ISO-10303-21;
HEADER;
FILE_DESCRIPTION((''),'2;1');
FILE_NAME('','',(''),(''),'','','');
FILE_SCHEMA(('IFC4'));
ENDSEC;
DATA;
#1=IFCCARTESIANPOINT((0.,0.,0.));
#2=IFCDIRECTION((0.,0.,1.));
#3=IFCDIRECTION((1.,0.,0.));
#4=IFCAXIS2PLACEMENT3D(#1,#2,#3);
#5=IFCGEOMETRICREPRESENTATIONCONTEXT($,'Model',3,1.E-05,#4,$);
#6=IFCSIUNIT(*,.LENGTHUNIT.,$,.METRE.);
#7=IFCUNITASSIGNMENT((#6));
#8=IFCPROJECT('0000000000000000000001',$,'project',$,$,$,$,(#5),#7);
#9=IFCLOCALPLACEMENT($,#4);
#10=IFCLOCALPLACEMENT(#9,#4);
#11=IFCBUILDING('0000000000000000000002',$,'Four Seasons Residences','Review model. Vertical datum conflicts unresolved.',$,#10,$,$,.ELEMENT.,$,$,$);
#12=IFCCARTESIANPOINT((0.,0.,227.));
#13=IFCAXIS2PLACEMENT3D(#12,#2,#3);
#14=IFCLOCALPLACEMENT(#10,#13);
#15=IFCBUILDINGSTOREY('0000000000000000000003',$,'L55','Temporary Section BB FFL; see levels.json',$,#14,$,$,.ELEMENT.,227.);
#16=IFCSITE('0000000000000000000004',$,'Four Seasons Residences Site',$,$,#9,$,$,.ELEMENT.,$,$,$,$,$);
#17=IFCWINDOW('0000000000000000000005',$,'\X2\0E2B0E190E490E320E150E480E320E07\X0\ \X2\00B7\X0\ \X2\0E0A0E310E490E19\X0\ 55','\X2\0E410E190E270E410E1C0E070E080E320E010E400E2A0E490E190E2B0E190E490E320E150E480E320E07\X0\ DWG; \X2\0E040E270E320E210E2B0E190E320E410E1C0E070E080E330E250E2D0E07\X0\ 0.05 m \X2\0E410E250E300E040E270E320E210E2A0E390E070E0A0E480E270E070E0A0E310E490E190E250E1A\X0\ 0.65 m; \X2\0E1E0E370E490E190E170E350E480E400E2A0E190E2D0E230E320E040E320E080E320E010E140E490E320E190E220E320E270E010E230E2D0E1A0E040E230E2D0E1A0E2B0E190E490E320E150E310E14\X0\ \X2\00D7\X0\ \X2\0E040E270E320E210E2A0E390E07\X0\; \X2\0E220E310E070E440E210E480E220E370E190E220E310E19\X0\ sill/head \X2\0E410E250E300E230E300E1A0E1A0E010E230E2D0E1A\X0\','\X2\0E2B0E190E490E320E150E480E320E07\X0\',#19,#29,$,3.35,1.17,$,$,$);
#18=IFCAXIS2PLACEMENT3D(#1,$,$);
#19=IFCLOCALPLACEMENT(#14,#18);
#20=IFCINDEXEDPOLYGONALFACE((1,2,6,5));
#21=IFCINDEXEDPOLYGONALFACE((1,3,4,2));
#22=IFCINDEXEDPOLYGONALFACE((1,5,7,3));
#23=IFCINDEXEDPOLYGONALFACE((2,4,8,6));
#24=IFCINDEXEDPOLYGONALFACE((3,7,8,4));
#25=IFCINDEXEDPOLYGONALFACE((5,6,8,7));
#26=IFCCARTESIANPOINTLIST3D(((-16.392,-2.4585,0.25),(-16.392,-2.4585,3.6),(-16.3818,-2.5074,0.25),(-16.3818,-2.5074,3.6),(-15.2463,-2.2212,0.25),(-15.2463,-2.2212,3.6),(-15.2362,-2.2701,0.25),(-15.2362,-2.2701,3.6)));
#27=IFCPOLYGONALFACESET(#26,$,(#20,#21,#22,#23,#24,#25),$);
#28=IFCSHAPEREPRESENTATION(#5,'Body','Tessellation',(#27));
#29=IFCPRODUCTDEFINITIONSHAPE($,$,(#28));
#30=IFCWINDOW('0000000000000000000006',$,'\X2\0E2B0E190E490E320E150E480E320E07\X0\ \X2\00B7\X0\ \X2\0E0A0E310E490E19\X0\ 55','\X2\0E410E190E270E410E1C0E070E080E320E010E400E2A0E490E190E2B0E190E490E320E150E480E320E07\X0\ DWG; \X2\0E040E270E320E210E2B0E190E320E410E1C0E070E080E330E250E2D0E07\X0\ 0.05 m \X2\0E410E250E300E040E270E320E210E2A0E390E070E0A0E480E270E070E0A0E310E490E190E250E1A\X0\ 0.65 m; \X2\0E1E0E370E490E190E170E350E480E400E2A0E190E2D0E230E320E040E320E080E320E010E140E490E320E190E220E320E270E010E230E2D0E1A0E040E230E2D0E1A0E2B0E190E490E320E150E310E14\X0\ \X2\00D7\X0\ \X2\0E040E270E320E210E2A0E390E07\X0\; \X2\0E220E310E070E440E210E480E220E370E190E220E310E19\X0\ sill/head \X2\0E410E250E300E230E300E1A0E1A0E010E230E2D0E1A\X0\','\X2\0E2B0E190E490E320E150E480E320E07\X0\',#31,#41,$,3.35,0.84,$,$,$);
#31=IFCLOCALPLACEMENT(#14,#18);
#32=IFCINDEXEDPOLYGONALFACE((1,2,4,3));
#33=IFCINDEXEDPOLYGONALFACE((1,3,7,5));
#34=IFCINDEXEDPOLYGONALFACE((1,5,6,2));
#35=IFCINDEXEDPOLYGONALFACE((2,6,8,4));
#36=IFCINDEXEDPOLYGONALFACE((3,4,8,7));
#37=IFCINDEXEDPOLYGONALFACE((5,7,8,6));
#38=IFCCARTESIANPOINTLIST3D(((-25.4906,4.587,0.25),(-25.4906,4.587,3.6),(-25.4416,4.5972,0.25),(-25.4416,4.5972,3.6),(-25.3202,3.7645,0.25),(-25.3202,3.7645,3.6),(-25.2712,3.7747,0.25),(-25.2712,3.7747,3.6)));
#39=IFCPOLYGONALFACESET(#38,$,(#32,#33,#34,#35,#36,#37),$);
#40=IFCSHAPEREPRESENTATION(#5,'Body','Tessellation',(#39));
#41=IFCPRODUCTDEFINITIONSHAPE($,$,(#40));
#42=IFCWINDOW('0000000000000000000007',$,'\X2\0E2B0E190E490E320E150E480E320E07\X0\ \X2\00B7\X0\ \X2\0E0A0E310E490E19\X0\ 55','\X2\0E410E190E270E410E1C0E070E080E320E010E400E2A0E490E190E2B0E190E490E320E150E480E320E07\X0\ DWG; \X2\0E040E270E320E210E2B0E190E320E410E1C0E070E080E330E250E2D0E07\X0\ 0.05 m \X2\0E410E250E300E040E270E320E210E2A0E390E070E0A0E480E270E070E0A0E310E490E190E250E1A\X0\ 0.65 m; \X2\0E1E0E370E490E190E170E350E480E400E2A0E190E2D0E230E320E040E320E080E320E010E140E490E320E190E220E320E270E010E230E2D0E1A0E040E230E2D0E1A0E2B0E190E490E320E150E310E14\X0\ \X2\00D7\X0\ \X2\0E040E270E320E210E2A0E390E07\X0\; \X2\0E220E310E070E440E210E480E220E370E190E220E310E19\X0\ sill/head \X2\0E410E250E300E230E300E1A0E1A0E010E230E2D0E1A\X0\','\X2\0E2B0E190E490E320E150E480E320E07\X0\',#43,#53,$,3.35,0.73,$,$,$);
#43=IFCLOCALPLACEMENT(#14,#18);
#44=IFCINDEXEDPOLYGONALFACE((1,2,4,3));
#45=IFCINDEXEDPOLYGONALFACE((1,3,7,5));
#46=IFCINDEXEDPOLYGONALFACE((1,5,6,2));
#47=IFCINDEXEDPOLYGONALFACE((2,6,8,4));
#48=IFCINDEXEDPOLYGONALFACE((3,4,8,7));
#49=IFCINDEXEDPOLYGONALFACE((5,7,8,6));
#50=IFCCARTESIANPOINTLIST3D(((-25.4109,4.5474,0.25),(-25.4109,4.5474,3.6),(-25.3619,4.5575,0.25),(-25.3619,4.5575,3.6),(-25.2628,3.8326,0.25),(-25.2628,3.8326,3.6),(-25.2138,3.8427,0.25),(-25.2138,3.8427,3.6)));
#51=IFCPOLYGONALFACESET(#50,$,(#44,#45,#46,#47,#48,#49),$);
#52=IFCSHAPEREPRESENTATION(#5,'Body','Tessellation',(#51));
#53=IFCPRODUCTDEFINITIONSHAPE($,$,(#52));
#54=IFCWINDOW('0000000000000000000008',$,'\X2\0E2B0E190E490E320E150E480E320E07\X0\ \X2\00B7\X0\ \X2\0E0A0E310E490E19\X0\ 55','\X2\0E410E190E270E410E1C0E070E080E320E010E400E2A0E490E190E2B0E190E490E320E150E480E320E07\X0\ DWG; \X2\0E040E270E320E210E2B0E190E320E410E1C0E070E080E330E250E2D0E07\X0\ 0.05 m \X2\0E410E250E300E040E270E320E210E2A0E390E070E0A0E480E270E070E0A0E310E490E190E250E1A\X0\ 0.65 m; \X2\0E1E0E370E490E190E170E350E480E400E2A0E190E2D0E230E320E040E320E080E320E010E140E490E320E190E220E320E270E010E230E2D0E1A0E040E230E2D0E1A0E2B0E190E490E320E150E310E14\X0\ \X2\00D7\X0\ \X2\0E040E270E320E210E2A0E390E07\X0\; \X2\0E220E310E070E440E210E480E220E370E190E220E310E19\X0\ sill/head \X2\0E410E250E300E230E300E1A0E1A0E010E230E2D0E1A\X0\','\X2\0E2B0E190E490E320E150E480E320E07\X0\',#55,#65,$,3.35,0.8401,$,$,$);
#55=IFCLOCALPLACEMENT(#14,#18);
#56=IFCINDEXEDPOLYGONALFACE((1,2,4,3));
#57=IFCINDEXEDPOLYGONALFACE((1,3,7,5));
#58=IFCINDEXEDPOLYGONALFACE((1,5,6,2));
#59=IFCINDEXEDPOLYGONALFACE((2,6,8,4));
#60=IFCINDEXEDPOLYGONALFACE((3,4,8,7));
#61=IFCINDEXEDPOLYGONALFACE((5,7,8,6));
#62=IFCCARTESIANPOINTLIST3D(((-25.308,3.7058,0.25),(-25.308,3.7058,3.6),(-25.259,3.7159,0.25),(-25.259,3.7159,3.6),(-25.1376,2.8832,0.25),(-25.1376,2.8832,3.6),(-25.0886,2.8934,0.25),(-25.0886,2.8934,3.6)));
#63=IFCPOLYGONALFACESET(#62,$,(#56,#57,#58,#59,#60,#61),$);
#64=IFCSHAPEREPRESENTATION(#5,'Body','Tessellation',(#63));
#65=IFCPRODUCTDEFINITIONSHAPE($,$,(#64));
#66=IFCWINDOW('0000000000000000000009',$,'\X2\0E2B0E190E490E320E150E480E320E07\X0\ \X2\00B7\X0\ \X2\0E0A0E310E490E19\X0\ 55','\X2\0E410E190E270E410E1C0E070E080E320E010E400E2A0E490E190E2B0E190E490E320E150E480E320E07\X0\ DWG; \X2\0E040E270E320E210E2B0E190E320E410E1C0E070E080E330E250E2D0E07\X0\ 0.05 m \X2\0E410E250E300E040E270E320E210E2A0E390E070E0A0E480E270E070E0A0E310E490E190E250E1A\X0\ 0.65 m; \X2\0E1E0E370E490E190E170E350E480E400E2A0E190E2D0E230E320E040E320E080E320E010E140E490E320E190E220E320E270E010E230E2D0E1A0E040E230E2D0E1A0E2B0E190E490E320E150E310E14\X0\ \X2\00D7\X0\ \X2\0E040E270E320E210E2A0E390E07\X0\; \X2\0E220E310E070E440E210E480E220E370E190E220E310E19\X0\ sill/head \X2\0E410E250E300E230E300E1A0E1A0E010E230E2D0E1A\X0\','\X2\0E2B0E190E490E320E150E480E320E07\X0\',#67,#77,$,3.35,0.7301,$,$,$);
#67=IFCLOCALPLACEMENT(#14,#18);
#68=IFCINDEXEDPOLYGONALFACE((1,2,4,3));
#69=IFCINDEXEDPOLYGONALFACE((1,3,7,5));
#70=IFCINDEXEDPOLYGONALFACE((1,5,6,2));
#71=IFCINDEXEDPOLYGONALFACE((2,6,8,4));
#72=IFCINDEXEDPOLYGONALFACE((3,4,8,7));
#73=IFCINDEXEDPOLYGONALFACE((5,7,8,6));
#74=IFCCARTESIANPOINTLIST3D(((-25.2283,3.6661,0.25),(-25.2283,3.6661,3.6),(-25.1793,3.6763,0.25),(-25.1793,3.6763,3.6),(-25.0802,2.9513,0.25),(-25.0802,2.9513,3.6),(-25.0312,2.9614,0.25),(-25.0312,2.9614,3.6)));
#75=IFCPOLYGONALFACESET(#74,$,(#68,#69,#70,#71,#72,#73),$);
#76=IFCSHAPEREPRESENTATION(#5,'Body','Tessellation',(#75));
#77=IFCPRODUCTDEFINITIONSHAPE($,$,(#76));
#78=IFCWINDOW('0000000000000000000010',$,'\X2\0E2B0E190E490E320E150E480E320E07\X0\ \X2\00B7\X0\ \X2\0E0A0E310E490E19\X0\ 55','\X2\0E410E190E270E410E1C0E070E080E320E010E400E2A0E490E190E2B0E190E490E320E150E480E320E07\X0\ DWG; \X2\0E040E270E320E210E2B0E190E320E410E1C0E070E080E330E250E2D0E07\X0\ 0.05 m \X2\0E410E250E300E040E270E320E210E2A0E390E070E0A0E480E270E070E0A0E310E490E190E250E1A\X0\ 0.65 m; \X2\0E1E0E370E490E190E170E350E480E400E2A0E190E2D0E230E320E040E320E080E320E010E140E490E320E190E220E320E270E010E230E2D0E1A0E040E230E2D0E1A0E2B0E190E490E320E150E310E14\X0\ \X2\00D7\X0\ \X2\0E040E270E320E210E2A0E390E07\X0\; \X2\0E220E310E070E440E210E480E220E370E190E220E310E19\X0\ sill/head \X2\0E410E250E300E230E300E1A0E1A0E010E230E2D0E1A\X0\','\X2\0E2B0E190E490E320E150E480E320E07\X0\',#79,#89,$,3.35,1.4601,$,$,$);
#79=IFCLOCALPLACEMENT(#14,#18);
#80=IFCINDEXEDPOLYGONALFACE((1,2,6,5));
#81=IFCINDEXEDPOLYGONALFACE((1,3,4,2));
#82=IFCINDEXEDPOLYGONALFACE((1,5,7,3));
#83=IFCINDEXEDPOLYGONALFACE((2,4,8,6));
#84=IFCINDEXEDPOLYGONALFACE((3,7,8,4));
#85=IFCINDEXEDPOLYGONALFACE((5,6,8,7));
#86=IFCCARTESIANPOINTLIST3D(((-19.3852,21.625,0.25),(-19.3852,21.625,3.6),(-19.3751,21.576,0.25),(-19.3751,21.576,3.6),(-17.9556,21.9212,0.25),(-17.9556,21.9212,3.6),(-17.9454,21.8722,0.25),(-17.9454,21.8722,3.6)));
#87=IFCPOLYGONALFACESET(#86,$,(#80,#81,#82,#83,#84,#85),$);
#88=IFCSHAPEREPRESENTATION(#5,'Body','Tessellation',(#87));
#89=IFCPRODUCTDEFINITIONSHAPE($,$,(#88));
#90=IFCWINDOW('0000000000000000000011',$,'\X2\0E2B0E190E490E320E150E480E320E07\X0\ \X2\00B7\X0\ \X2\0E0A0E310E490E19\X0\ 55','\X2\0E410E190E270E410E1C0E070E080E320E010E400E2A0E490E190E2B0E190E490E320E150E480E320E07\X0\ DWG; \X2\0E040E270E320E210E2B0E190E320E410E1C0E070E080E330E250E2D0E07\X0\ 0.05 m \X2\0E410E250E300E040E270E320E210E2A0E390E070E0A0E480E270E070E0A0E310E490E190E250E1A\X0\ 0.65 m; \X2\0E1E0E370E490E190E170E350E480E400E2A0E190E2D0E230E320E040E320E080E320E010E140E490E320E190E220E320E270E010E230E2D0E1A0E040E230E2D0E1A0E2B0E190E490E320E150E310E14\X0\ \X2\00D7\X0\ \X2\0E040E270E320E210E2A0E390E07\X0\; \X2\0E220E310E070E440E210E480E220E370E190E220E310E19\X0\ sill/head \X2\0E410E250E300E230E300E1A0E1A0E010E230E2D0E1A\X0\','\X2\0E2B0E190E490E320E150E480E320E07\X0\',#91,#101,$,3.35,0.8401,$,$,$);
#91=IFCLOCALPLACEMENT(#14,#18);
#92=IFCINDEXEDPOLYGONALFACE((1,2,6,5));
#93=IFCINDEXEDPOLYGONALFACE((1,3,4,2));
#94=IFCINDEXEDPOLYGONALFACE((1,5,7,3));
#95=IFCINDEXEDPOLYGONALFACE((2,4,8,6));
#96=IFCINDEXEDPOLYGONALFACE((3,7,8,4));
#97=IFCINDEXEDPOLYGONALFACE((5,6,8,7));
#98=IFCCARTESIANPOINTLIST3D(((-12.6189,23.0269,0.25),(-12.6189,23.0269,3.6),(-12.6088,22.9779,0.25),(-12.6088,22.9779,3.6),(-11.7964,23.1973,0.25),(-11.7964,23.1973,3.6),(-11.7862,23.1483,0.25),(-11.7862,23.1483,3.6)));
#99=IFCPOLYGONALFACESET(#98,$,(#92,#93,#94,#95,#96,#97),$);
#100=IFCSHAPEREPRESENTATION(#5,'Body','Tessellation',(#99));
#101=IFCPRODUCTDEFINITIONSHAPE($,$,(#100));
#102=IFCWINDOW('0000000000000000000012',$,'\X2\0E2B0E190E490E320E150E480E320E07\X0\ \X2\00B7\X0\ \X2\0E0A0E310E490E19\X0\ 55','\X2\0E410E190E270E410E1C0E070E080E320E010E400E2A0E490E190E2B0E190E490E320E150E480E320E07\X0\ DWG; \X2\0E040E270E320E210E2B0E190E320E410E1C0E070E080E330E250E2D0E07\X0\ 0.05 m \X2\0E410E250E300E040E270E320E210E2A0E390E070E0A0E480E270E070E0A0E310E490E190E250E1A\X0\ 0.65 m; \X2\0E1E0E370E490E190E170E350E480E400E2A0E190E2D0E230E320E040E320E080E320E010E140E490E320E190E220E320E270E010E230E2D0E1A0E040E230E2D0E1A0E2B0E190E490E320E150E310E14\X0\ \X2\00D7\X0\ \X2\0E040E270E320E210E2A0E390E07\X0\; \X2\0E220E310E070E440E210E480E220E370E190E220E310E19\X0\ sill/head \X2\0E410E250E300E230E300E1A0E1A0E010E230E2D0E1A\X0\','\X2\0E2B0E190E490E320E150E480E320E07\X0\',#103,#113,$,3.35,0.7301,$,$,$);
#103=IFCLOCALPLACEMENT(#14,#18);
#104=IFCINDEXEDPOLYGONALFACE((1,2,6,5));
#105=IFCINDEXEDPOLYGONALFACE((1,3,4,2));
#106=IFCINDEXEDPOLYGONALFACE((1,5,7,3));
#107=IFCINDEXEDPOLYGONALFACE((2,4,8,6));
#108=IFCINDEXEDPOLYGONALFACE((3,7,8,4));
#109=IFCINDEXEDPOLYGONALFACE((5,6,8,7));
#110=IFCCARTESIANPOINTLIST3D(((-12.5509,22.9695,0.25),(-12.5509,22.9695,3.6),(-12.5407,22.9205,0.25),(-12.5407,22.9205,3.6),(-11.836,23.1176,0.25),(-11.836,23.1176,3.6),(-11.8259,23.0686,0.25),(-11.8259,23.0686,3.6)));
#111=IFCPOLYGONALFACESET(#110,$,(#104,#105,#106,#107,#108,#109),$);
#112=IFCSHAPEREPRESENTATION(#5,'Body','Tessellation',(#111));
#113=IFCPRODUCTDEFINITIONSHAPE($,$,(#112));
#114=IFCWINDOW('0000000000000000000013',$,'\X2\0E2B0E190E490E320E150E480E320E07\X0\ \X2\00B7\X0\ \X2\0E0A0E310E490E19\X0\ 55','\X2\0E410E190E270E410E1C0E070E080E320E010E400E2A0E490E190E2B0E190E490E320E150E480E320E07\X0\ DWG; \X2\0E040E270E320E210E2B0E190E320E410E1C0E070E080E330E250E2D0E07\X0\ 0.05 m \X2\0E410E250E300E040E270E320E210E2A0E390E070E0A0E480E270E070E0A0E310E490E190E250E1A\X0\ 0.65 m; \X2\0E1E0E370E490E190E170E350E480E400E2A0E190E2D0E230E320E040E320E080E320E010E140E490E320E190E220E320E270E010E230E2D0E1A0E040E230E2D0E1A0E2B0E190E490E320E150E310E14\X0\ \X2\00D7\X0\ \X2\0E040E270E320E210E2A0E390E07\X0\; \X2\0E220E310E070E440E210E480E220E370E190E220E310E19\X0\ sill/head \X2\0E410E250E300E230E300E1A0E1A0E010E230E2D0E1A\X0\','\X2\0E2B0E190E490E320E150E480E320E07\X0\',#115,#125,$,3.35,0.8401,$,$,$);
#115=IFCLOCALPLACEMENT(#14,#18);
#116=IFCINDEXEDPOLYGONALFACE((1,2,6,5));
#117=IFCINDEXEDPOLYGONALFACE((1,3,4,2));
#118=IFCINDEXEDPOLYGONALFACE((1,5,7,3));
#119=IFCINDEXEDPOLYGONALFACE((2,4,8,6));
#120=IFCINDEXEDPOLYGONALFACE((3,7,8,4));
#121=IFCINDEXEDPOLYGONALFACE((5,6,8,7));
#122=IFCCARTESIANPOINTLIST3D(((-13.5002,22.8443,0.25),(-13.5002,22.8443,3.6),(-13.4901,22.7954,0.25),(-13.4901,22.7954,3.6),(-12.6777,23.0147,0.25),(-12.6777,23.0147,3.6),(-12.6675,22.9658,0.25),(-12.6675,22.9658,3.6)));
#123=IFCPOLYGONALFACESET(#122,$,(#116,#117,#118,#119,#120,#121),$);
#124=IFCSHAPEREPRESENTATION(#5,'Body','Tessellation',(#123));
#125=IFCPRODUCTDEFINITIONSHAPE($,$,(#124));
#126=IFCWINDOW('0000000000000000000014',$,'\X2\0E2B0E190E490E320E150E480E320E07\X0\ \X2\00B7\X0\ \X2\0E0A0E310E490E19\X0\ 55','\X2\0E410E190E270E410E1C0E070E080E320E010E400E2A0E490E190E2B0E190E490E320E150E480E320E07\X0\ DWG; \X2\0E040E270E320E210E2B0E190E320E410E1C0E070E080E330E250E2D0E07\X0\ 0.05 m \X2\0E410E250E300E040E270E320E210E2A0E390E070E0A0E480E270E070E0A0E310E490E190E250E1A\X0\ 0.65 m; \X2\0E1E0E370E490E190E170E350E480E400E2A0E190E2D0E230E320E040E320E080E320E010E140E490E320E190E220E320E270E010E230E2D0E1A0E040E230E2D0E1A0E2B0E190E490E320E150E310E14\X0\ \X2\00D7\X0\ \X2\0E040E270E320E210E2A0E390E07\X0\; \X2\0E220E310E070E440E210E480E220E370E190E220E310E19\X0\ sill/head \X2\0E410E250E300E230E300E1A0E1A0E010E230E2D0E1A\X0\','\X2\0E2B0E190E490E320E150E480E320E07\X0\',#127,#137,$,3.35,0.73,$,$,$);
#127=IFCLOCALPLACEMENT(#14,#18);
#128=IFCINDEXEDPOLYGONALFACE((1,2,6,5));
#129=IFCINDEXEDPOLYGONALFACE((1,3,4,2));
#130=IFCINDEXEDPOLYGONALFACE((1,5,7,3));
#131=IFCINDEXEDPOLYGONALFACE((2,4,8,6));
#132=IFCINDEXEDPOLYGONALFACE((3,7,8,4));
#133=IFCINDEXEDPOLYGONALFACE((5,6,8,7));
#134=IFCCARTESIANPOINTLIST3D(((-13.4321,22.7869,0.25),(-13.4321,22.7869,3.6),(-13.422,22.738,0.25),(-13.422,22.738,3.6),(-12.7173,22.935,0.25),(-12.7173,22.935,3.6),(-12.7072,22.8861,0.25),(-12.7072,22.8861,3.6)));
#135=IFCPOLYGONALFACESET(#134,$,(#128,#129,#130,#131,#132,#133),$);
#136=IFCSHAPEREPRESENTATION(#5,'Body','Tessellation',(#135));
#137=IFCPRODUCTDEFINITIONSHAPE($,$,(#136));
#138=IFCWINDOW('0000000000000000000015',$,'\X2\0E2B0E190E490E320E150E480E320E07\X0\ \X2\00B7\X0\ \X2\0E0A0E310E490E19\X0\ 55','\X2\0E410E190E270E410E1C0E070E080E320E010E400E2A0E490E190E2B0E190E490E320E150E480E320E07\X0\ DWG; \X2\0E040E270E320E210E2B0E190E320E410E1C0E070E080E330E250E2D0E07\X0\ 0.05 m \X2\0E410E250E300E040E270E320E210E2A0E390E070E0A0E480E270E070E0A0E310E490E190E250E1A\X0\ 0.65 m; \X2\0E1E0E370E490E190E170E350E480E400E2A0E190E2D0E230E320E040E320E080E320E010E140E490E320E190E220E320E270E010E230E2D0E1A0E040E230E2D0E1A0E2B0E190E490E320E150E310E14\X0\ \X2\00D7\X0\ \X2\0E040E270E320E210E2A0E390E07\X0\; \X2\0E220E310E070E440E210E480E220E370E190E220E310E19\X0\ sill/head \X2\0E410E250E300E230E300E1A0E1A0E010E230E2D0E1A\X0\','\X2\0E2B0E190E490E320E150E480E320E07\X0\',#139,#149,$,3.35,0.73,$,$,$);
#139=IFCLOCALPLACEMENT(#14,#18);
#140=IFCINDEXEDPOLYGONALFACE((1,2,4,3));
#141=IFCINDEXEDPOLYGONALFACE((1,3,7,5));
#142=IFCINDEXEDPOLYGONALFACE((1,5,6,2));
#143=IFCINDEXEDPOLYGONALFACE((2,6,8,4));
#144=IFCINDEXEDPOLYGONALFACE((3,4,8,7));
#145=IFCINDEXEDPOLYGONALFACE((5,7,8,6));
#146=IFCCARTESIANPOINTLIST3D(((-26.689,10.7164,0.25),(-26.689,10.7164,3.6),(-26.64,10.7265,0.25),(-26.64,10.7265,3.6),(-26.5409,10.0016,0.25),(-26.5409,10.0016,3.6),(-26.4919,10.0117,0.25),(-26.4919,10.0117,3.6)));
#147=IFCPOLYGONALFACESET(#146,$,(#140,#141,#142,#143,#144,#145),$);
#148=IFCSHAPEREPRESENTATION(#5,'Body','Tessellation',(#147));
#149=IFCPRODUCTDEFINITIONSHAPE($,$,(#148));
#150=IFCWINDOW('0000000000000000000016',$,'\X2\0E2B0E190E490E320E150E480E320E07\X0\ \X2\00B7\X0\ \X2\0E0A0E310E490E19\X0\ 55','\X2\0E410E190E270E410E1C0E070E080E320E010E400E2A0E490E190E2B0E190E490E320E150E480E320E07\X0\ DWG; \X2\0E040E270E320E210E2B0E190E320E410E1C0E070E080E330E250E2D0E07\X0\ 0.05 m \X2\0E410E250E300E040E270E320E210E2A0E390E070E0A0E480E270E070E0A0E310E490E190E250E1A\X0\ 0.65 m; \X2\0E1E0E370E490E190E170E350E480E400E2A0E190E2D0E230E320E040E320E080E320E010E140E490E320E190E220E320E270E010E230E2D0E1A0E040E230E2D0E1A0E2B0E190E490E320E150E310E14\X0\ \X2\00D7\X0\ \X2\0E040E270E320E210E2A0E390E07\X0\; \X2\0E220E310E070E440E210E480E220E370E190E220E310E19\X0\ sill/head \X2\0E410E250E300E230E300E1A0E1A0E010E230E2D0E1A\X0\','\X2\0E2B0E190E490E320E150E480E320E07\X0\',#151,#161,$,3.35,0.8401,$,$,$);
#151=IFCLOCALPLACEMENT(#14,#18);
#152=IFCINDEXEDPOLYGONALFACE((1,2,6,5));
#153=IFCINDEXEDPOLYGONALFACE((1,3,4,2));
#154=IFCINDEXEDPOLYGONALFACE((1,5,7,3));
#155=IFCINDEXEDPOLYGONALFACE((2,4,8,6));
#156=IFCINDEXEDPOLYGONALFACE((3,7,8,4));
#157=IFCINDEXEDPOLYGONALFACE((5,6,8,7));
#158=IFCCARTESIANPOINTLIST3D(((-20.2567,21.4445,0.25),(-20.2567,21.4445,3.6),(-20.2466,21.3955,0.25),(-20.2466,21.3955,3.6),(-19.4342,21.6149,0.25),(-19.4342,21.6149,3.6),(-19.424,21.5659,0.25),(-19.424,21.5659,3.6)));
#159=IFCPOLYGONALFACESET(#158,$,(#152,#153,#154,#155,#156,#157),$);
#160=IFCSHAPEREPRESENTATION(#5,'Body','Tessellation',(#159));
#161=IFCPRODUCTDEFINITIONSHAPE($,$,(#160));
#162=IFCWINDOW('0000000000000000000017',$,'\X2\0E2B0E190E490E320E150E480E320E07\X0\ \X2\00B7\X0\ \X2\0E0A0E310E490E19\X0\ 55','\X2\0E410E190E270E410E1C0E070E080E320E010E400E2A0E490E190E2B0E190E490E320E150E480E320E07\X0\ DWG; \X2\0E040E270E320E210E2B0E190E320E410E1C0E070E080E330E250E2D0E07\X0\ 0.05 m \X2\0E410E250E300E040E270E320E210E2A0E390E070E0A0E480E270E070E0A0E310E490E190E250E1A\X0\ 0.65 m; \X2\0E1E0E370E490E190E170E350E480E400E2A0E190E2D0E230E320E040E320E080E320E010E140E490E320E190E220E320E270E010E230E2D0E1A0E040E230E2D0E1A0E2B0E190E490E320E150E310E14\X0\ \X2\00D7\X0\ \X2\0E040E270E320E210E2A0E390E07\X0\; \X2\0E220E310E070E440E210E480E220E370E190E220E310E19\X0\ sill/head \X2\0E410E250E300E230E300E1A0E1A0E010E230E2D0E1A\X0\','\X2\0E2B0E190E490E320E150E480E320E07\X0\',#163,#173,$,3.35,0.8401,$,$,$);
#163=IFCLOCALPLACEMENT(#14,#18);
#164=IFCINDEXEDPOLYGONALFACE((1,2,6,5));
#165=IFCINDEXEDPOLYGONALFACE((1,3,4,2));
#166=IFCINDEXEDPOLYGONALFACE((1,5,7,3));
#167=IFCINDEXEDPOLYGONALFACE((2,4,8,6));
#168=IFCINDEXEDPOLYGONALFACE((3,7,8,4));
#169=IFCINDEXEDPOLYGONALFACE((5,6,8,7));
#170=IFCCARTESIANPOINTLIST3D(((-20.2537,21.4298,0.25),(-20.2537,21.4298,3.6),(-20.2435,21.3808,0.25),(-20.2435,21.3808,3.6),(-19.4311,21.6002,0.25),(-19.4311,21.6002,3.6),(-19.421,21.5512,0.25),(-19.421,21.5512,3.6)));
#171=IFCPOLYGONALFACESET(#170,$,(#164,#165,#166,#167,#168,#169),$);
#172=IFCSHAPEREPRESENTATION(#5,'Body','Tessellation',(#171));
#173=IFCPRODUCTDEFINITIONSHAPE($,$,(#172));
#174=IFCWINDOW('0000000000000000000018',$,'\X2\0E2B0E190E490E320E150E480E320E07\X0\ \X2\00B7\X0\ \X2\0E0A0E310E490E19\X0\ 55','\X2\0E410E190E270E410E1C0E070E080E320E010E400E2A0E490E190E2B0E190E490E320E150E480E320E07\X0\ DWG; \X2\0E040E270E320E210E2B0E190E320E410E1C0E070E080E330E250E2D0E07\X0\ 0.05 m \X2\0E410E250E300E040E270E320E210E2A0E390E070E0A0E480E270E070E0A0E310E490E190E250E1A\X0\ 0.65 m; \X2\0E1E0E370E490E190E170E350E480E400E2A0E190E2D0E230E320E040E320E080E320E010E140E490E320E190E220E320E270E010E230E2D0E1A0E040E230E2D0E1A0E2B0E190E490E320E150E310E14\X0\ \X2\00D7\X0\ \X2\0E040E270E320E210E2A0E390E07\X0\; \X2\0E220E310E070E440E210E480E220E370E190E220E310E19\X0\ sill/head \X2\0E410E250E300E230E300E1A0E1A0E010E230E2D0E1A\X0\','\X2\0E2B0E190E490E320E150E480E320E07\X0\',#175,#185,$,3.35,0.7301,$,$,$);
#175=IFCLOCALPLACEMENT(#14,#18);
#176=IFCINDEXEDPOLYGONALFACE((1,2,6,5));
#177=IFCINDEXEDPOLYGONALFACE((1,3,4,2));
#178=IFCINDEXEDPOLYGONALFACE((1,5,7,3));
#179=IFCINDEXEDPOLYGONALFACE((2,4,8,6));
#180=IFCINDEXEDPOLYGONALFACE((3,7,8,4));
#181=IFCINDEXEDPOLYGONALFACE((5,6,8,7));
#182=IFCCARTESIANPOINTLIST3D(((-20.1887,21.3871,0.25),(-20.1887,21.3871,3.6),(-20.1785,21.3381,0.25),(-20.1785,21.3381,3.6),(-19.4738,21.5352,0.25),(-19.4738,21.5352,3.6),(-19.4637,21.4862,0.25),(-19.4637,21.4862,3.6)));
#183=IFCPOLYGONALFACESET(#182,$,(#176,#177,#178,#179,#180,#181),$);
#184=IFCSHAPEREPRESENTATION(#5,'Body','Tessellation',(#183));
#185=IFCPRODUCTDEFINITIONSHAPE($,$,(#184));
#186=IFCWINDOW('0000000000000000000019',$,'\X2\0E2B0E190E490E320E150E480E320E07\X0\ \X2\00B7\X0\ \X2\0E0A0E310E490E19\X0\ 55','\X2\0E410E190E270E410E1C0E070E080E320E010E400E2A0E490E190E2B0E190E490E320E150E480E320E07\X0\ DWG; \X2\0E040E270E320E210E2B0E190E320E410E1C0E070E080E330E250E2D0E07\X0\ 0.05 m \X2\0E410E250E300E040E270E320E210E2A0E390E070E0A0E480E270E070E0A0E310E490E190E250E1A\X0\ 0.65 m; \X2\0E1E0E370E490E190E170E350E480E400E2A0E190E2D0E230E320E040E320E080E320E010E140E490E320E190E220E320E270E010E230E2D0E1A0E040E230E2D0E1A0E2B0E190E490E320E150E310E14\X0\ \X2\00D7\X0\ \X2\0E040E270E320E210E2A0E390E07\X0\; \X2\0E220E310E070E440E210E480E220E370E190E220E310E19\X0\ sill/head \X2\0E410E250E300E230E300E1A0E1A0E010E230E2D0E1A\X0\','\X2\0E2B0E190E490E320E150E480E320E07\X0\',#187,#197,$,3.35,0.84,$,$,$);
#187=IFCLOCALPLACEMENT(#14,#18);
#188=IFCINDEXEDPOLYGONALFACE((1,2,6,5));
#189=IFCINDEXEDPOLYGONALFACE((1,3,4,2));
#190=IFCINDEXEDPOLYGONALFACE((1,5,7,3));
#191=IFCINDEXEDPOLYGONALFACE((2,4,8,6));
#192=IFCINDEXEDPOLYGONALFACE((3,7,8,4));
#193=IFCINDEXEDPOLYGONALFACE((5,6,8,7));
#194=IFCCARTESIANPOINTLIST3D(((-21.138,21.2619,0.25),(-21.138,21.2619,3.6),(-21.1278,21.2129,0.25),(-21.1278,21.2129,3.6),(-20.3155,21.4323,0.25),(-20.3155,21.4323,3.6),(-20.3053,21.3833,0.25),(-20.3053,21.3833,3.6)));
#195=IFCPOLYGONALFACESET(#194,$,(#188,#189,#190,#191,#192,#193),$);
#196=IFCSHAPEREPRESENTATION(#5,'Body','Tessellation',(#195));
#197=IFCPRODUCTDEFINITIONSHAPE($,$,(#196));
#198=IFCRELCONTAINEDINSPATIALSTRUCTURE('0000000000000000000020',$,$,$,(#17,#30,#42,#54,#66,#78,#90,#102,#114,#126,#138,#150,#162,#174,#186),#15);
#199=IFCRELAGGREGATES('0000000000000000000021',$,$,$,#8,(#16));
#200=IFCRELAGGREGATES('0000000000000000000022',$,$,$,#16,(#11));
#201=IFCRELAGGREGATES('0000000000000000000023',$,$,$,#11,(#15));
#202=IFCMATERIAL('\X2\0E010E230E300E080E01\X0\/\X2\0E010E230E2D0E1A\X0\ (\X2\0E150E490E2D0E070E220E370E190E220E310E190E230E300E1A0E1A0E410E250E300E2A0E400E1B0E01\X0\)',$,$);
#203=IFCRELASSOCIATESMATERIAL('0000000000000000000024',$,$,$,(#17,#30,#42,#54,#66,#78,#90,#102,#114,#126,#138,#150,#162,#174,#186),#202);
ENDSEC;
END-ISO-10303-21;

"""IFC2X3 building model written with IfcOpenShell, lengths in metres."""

from ifc_helpers import new_model, si_unit, frame, origin_with_axes, place, context, project, spatial, polyline, outline, extrude, material, element, save


model = new_model("IFC2X3")

# Units and contexts
model_context = context("Model", 3, precision=1e-05, world=origin_with_axes())
ifc_project = project(units=[si_unit("LENGTHUNIT", "METRE")], contexts=[model_context])

# Site, building, storey
site_placement = place(None, origin_with_axes())
site = spatial("IfcSite", under=ifc_project, at=site_placement, Name="Four Seasons Residences Site", CompositionType="ELEMENT")
building_placement = place(site_placement, origin_with_axes())
building = spatial("IfcBuilding", under=site, at=building_placement, Name="Four Seasons Residences", Description="Review model. Vertical datum conflicts unresolved.", CompositionType="ELEMENT")
storey_placement = place(building_placement, frame((0.0, 0.0, 227.0), z_axis=(0.0, 0.0, 1.0), x_axis=(1.0, 0.0, 0.0)))
storey = spatial("IfcBuildingStorey", under=building, at=storey_placement, Name="L55", Description="Temporary Section BB FFL; see levels.json", CompositionType="ELEMENT", Elevation=227.0)

# Windows
ifc_material = material(Name="กระจก/กรอบ (ต้องยืนยันระบบและสเปก)")
window_1_placement = place(storey_placement, origin_with_axes())
element("IfcWindow", 1, at=window_1_placement, inside=storey, material=ifc_material, Name="หน้าต่าง · ชั้น 55", Description="แนวแผงจากเส้นหน้าต่าง DWG; ความหนาแผงจำลอง 0.05 m และความสูงช่วงชั้นลบ 0.65 m; พื้นที่เสนอราคาจากด้านยาวกรอบครอบหน้าตัด × ความสูง; ยังไม่ยืนยัน sill/head และระบบกรอบ", ObjectType="หน้าต่าง", OverallHeight=3.35, OverallWidth=1.17, context=model_context, shape_type="SweptSolid", body=[
    extrude(outline(polyline([(-15.2463, -2.2212), (-15.2362, -2.2701), (-16.3818, -2.5074), (-16.392, -2.4585), (-15.2463, -2.2212)])), frame((0.0, 0.0, 0.25), z_axis=(0.0, 0.0, 1.0), x_axis=(1.0, 0.0, 0.0)), (0.0, 0.0, 1.0), 3.35),
])
window_2_placement = place(storey_placement, origin_with_axes())
element("IfcWindow", 2, at=window_2_placement, inside=storey, material=ifc_material, Name="หน้าต่าง · ชั้น 55", Description="แนวแผงจากเส้นหน้าต่าง DWG; ความหนาแผงจำลอง 0.05 m และความสูงช่วงชั้นลบ 0.65 m; พื้นที่เสนอราคาจากด้านยาวกรอบครอบหน้าตัด × ความสูง; ยังไม่ยืนยัน sill/head และระบบกรอบ", ObjectType="หน้าต่าง", OverallHeight=3.35, OverallWidth=0.84, context=model_context, shape_type="SweptSolid", body=[
    extrude(outline(polyline([(-25.2712, 3.7747), (-25.3202, 3.7645), (-25.4906, 4.587), (-25.4416, 4.5972), (-25.2712, 3.7747)])), frame((0.0, 0.0, 0.25), z_axis=(0.0, 0.0, 1.0), x_axis=(1.0, 0.0, 0.0)), (0.0, 0.0, 1.0), 3.35),
])
window_3_placement = place(storey_placement, origin_with_axes())
element("IfcWindow", 3, at=window_3_placement, inside=storey, material=ifc_material, Name="หน้าต่าง · ชั้น 55", Description="แนวแผงจากเส้นหน้าต่าง DWG; ความหนาแผงจำลอง 0.05 m และความสูงช่วงชั้นลบ 0.65 m; พื้นที่เสนอราคาจากด้านยาวกรอบครอบหน้าตัด × ความสูง; ยังไม่ยืนยัน sill/head และระบบกรอบ", ObjectType="หน้าต่าง", OverallHeight=3.35, OverallWidth=0.73, context=model_context, shape_type="SweptSolid", body=[
    extrude(outline(polyline([(-25.2138, 3.8427), (-25.2628, 3.8326), (-25.4109, 4.5474), (-25.3619, 4.5575), (-25.2138, 3.8427)])), frame((0.0, 0.0, 0.25), z_axis=(0.0, 0.0, 1.0), x_axis=(1.0, 0.0, 0.0)), (0.0, 0.0, 1.0), 3.35),
])
window_4_placement = place(storey_placement, origin_with_axes())
element("IfcWindow", 4, at=window_4_placement, inside=storey, material=ifc_material, Name="หน้าต่าง · ชั้น 55", Description="แนวแผงจากเส้นหน้าต่าง DWG; ความหนาแผงจำลอง 0.05 m และความสูงช่วงชั้นลบ 0.65 m; พื้นที่เสนอราคาจากด้านยาวกรอบครอบหน้าตัด × ความสูง; ยังไม่ยืนยัน sill/head และระบบกรอบ", ObjectType="หน้าต่าง", OverallHeight=3.35, OverallWidth=0.8401, context=model_context, shape_type="SweptSolid", body=[
    extrude(outline(polyline([(-25.0886, 2.8934), (-25.1376, 2.8832), (-25.308, 3.7058), (-25.259, 3.7159), (-25.0886, 2.8934)])), frame((0.0, 0.0, 0.25), z_axis=(0.0, 0.0, 1.0), x_axis=(1.0, 0.0, 0.0)), (0.0, 0.0, 1.0), 3.35),
])
window_5_placement = place(storey_placement, origin_with_axes())
element("IfcWindow", 5, at=window_5_placement, inside=storey, material=ifc_material, Name="หน้าต่าง · ชั้น 55", Description="แนวแผงจากเส้นหน้าต่าง DWG; ความหนาแผงจำลอง 0.05 m และความสูงช่วงชั้นลบ 0.65 m; พื้นที่เสนอราคาจากด้านยาวกรอบครอบหน้าตัด × ความสูง; ยังไม่ยืนยัน sill/head และระบบกรอบ", ObjectType="หน้าต่าง", OverallHeight=3.35, OverallWidth=0.7301, context=model_context, shape_type="SweptSolid", body=[
    extrude(outline(polyline([(-25.0312, 2.9614), (-25.0802, 2.9513), (-25.2283, 3.6661), (-25.1793, 3.6763), (-25.0312, 2.9614)])), frame((0.0, 0.0, 0.25), z_axis=(0.0, 0.0, 1.0), x_axis=(1.0, 0.0, 0.0)), (0.0, 0.0, 1.0), 3.35),
])
window_6_placement = place(storey_placement, origin_with_axes())
element("IfcWindow", 6, at=window_6_placement, inside=storey, material=ifc_material, Name="หน้าต่าง · ชั้น 55", Description="แนวแผงจากเส้นหน้าต่าง DWG; ความหนาแผงจำลอง 0.05 m และความสูงช่วงชั้นลบ 0.65 m; พื้นที่เสนอราคาจากด้านยาวกรอบครอบหน้าตัด × ความสูง; ยังไม่ยืนยัน sill/head และระบบกรอบ", ObjectType="หน้าต่าง", OverallHeight=3.35, OverallWidth=1.4601, context=model_context, shape_type="SweptSolid", body=[
    extrude(outline(polyline([(-17.9556, 21.9212), (-17.9454, 21.8722), (-19.3751, 21.576), (-19.3852, 21.625), (-17.9556, 21.9212)])), frame((0.0, 0.0, 0.25), z_axis=(0.0, 0.0, 1.0), x_axis=(1.0, 0.0, 0.0)), (0.0, 0.0, 1.0), 3.35),
])
window_7_placement = place(storey_placement, origin_with_axes())
element("IfcWindow", 7, at=window_7_placement, inside=storey, material=ifc_material, Name="หน้าต่าง · ชั้น 55", Description="แนวแผงจากเส้นหน้าต่าง DWG; ความหนาแผงจำลอง 0.05 m และความสูงช่วงชั้นลบ 0.65 m; พื้นที่เสนอราคาจากด้านยาวกรอบครอบหน้าตัด × ความสูง; ยังไม่ยืนยัน sill/head และระบบกรอบ", ObjectType="หน้าต่าง", OverallHeight=3.35, OverallWidth=0.8401, context=model_context, shape_type="SweptSolid", body=[
    extrude(outline(polyline([(-12.6088, 22.9779), (-12.6189, 23.0269), (-11.7964, 23.1973), (-11.7862, 23.1483), (-12.6088, 22.9779)])), frame((0.0, 0.0, 0.25), z_axis=(0.0, 0.0, 1.0), x_axis=(1.0, 0.0, 0.0)), (0.0, 0.0, 1.0), 3.35),
])
window_8_placement = place(storey_placement, origin_with_axes())
element("IfcWindow", 8, at=window_8_placement, inside=storey, material=ifc_material, Name="หน้าต่าง · ชั้น 55", Description="แนวแผงจากเส้นหน้าต่าง DWG; ความหนาแผงจำลอง 0.05 m และความสูงช่วงชั้นลบ 0.65 m; พื้นที่เสนอราคาจากด้านยาวกรอบครอบหน้าตัด × ความสูง; ยังไม่ยืนยัน sill/head และระบบกรอบ", ObjectType="หน้าต่าง", OverallHeight=3.35, OverallWidth=0.7301, context=model_context, shape_type="SweptSolid", body=[
    extrude(outline(polyline([(-12.5407, 22.9205), (-12.5509, 22.9695), (-11.836, 23.1176), (-11.8259, 23.0686), (-12.5407, 22.9205)])), frame((0.0, 0.0, 0.25), z_axis=(0.0, 0.0, 1.0), x_axis=(1.0, 0.0, 0.0)), (0.0, 0.0, 1.0), 3.35),
])
window_9_placement = place(storey_placement, origin_with_axes())
element("IfcWindow", 9, at=window_9_placement, inside=storey, material=ifc_material, Name="หน้าต่าง · ชั้น 55", Description="แนวแผงจากเส้นหน้าต่าง DWG; ความหนาแผงจำลอง 0.05 m และความสูงช่วงชั้นลบ 0.65 m; พื้นที่เสนอราคาจากด้านยาวกรอบครอบหน้าตัด × ความสูง; ยังไม่ยืนยัน sill/head และระบบกรอบ", ObjectType="หน้าต่าง", OverallHeight=3.35, OverallWidth=0.8401, context=model_context, shape_type="SweptSolid", body=[
    extrude(outline(polyline([(-13.4901, 22.7954), (-13.5002, 22.8443), (-12.6777, 23.0147), (-12.6675, 22.9658), (-13.4901, 22.7954)])), frame((0.0, 0.0, 0.25), z_axis=(0.0, 0.0, 1.0), x_axis=(1.0, 0.0, 0.0)), (0.0, 0.0, 1.0), 3.35),
])
window_10_placement = place(storey_placement, origin_with_axes())
element("IfcWindow", 10, at=window_10_placement, inside=storey, material=ifc_material, Name="หน้าต่าง · ชั้น 55", Description="แนวแผงจากเส้นหน้าต่าง DWG; ความหนาแผงจำลอง 0.05 m และความสูงช่วงชั้นลบ 0.65 m; พื้นที่เสนอราคาจากด้านยาวกรอบครอบหน้าตัด × ความสูง; ยังไม่ยืนยัน sill/head และระบบกรอบ", ObjectType="หน้าต่าง", OverallHeight=3.35, OverallWidth=0.73, context=model_context, shape_type="SweptSolid", body=[
    extrude(outline(polyline([(-13.422, 22.738), (-13.4321, 22.7869), (-12.7173, 22.935), (-12.7072, 22.8861), (-13.422, 22.738)])), frame((0.0, 0.0, 0.25), z_axis=(0.0, 0.0, 1.0), x_axis=(1.0, 0.0, 0.0)), (0.0, 0.0, 1.0), 3.35),
])
window_11_placement = place(storey_placement, origin_with_axes())
element("IfcWindow", 11, at=window_11_placement, inside=storey, material=ifc_material, Name="หน้าต่าง · ชั้น 55", Description="แนวแผงจากเส้นหน้าต่าง DWG; ความหนาแผงจำลอง 0.05 m และความสูงช่วงชั้นลบ 0.65 m; พื้นที่เสนอราคาจากด้านยาวกรอบครอบหน้าตัด × ความสูง; ยังไม่ยืนยัน sill/head และระบบกรอบ", ObjectType="หน้าต่าง", OverallHeight=3.35, OverallWidth=0.73, context=model_context, shape_type="SweptSolid", body=[
    extrude(outline(polyline([(-26.689, 10.7164), (-26.64, 10.7265), (-26.4919, 10.0117), (-26.5409, 10.0016), (-26.689, 10.7164)])), frame((0.0, 0.0, 0.25), z_axis=(0.0, 0.0, 1.0), x_axis=(1.0, 0.0, 0.0)), (0.0, 0.0, 1.0), 3.35),
])
window_12_placement = place(storey_placement, origin_with_axes())
element("IfcWindow", 12, at=window_12_placement, inside=storey, material=ifc_material, Name="หน้าต่าง · ชั้น 55", Description="แนวแผงจากเส้นหน้าต่าง DWG; ความหนาแผงจำลอง 0.05 m และความสูงช่วงชั้นลบ 0.65 m; พื้นที่เสนอราคาจากด้านยาวกรอบครอบหน้าตัด × ความสูง; ยังไม่ยืนยัน sill/head และระบบกรอบ", ObjectType="หน้าต่าง", OverallHeight=3.35, OverallWidth=0.8401, context=model_context, shape_type="SweptSolid", body=[
    extrude(outline(polyline([(-20.2466, 21.3955), (-20.2567, 21.4445), (-19.4342, 21.6149), (-19.424, 21.5659), (-20.2466, 21.3955)])), frame((0.0, 0.0, 0.25), z_axis=(0.0, 0.0, 1.0), x_axis=(1.0, 0.0, 0.0)), (0.0, 0.0, 1.0), 3.35),
])
window_13_placement = place(storey_placement, origin_with_axes())
element("IfcWindow", 13, at=window_13_placement, inside=storey, material=ifc_material, Name="หน้าต่าง · ชั้น 55", Description="แนวแผงจากเส้นหน้าต่าง DWG; ความหนาแผงจำลอง 0.05 m และความสูงช่วงชั้นลบ 0.65 m; พื้นที่เสนอราคาจากด้านยาวกรอบครอบหน้าตัด × ความสูง; ยังไม่ยืนยัน sill/head และระบบกรอบ", ObjectType="หน้าต่าง", OverallHeight=3.35, OverallWidth=0.8401, context=model_context, shape_type="SweptSolid", body=[
    extrude(outline(polyline([(-20.2435, 21.3808), (-20.2537, 21.4298), (-19.4311, 21.6002), (-19.421, 21.5512), (-20.2435, 21.3808)])), frame((0.0, 0.0, 0.25), z_axis=(0.0, 0.0, 1.0), x_axis=(1.0, 0.0, 0.0)), (0.0, 0.0, 1.0), 3.35),
])
window_14_placement = place(storey_placement, origin_with_axes())
element("IfcWindow", 14, at=window_14_placement, inside=storey, material=ifc_material, Name="หน้าต่าง · ชั้น 55", Description="แนวแผงจากเส้นหน้าต่าง DWG; ความหนาแผงจำลอง 0.05 m และความสูงช่วงชั้นลบ 0.65 m; พื้นที่เสนอราคาจากด้านยาวกรอบครอบหน้าตัด × ความสูง; ยังไม่ยืนยัน sill/head และระบบกรอบ", ObjectType="หน้าต่าง", OverallHeight=3.35, OverallWidth=0.7301, context=model_context, shape_type="SweptSolid", body=[
    extrude(outline(polyline([(-20.1785, 21.3381), (-20.1887, 21.3871), (-19.4738, 21.5352), (-19.4637, 21.4862), (-20.1785, 21.3381)])), frame((0.0, 0.0, 0.25), z_axis=(0.0, 0.0, 1.0), x_axis=(1.0, 0.0, 0.0)), (0.0, 0.0, 1.0), 3.35),
])
window_15_placement = place(storey_placement, origin_with_axes())
element("IfcWindow", 15, at=window_15_placement, inside=storey, material=ifc_material, Name="หน้าต่าง · ชั้น 55", Description="แนวแผงจากเส้นหน้าต่าง DWG; ความหนาแผงจำลอง 0.05 m และความสูงช่วงชั้นลบ 0.65 m; พื้นที่เสนอราคาจากด้านยาวกรอบครอบหน้าตัด × ความสูง; ยังไม่ยืนยัน sill/head และระบบกรอบ", ObjectType="หน้าต่าง", OverallHeight=3.35, OverallWidth=0.84, context=model_context, shape_type="SweptSolid", body=[
    extrude(outline(polyline([(-21.1278, 21.2129), (-21.138, 21.2619), (-20.3155, 21.4323), (-20.3053, 21.3833), (-21.1278, 21.2129)])), frame((0.0, 0.0, 0.25), z_axis=(0.0, 0.0, 1.0), x_axis=(1.0, 0.0, 0.0)), (0.0, 0.0, 1.0), 3.35),
])

save(model, "model.ifc")
